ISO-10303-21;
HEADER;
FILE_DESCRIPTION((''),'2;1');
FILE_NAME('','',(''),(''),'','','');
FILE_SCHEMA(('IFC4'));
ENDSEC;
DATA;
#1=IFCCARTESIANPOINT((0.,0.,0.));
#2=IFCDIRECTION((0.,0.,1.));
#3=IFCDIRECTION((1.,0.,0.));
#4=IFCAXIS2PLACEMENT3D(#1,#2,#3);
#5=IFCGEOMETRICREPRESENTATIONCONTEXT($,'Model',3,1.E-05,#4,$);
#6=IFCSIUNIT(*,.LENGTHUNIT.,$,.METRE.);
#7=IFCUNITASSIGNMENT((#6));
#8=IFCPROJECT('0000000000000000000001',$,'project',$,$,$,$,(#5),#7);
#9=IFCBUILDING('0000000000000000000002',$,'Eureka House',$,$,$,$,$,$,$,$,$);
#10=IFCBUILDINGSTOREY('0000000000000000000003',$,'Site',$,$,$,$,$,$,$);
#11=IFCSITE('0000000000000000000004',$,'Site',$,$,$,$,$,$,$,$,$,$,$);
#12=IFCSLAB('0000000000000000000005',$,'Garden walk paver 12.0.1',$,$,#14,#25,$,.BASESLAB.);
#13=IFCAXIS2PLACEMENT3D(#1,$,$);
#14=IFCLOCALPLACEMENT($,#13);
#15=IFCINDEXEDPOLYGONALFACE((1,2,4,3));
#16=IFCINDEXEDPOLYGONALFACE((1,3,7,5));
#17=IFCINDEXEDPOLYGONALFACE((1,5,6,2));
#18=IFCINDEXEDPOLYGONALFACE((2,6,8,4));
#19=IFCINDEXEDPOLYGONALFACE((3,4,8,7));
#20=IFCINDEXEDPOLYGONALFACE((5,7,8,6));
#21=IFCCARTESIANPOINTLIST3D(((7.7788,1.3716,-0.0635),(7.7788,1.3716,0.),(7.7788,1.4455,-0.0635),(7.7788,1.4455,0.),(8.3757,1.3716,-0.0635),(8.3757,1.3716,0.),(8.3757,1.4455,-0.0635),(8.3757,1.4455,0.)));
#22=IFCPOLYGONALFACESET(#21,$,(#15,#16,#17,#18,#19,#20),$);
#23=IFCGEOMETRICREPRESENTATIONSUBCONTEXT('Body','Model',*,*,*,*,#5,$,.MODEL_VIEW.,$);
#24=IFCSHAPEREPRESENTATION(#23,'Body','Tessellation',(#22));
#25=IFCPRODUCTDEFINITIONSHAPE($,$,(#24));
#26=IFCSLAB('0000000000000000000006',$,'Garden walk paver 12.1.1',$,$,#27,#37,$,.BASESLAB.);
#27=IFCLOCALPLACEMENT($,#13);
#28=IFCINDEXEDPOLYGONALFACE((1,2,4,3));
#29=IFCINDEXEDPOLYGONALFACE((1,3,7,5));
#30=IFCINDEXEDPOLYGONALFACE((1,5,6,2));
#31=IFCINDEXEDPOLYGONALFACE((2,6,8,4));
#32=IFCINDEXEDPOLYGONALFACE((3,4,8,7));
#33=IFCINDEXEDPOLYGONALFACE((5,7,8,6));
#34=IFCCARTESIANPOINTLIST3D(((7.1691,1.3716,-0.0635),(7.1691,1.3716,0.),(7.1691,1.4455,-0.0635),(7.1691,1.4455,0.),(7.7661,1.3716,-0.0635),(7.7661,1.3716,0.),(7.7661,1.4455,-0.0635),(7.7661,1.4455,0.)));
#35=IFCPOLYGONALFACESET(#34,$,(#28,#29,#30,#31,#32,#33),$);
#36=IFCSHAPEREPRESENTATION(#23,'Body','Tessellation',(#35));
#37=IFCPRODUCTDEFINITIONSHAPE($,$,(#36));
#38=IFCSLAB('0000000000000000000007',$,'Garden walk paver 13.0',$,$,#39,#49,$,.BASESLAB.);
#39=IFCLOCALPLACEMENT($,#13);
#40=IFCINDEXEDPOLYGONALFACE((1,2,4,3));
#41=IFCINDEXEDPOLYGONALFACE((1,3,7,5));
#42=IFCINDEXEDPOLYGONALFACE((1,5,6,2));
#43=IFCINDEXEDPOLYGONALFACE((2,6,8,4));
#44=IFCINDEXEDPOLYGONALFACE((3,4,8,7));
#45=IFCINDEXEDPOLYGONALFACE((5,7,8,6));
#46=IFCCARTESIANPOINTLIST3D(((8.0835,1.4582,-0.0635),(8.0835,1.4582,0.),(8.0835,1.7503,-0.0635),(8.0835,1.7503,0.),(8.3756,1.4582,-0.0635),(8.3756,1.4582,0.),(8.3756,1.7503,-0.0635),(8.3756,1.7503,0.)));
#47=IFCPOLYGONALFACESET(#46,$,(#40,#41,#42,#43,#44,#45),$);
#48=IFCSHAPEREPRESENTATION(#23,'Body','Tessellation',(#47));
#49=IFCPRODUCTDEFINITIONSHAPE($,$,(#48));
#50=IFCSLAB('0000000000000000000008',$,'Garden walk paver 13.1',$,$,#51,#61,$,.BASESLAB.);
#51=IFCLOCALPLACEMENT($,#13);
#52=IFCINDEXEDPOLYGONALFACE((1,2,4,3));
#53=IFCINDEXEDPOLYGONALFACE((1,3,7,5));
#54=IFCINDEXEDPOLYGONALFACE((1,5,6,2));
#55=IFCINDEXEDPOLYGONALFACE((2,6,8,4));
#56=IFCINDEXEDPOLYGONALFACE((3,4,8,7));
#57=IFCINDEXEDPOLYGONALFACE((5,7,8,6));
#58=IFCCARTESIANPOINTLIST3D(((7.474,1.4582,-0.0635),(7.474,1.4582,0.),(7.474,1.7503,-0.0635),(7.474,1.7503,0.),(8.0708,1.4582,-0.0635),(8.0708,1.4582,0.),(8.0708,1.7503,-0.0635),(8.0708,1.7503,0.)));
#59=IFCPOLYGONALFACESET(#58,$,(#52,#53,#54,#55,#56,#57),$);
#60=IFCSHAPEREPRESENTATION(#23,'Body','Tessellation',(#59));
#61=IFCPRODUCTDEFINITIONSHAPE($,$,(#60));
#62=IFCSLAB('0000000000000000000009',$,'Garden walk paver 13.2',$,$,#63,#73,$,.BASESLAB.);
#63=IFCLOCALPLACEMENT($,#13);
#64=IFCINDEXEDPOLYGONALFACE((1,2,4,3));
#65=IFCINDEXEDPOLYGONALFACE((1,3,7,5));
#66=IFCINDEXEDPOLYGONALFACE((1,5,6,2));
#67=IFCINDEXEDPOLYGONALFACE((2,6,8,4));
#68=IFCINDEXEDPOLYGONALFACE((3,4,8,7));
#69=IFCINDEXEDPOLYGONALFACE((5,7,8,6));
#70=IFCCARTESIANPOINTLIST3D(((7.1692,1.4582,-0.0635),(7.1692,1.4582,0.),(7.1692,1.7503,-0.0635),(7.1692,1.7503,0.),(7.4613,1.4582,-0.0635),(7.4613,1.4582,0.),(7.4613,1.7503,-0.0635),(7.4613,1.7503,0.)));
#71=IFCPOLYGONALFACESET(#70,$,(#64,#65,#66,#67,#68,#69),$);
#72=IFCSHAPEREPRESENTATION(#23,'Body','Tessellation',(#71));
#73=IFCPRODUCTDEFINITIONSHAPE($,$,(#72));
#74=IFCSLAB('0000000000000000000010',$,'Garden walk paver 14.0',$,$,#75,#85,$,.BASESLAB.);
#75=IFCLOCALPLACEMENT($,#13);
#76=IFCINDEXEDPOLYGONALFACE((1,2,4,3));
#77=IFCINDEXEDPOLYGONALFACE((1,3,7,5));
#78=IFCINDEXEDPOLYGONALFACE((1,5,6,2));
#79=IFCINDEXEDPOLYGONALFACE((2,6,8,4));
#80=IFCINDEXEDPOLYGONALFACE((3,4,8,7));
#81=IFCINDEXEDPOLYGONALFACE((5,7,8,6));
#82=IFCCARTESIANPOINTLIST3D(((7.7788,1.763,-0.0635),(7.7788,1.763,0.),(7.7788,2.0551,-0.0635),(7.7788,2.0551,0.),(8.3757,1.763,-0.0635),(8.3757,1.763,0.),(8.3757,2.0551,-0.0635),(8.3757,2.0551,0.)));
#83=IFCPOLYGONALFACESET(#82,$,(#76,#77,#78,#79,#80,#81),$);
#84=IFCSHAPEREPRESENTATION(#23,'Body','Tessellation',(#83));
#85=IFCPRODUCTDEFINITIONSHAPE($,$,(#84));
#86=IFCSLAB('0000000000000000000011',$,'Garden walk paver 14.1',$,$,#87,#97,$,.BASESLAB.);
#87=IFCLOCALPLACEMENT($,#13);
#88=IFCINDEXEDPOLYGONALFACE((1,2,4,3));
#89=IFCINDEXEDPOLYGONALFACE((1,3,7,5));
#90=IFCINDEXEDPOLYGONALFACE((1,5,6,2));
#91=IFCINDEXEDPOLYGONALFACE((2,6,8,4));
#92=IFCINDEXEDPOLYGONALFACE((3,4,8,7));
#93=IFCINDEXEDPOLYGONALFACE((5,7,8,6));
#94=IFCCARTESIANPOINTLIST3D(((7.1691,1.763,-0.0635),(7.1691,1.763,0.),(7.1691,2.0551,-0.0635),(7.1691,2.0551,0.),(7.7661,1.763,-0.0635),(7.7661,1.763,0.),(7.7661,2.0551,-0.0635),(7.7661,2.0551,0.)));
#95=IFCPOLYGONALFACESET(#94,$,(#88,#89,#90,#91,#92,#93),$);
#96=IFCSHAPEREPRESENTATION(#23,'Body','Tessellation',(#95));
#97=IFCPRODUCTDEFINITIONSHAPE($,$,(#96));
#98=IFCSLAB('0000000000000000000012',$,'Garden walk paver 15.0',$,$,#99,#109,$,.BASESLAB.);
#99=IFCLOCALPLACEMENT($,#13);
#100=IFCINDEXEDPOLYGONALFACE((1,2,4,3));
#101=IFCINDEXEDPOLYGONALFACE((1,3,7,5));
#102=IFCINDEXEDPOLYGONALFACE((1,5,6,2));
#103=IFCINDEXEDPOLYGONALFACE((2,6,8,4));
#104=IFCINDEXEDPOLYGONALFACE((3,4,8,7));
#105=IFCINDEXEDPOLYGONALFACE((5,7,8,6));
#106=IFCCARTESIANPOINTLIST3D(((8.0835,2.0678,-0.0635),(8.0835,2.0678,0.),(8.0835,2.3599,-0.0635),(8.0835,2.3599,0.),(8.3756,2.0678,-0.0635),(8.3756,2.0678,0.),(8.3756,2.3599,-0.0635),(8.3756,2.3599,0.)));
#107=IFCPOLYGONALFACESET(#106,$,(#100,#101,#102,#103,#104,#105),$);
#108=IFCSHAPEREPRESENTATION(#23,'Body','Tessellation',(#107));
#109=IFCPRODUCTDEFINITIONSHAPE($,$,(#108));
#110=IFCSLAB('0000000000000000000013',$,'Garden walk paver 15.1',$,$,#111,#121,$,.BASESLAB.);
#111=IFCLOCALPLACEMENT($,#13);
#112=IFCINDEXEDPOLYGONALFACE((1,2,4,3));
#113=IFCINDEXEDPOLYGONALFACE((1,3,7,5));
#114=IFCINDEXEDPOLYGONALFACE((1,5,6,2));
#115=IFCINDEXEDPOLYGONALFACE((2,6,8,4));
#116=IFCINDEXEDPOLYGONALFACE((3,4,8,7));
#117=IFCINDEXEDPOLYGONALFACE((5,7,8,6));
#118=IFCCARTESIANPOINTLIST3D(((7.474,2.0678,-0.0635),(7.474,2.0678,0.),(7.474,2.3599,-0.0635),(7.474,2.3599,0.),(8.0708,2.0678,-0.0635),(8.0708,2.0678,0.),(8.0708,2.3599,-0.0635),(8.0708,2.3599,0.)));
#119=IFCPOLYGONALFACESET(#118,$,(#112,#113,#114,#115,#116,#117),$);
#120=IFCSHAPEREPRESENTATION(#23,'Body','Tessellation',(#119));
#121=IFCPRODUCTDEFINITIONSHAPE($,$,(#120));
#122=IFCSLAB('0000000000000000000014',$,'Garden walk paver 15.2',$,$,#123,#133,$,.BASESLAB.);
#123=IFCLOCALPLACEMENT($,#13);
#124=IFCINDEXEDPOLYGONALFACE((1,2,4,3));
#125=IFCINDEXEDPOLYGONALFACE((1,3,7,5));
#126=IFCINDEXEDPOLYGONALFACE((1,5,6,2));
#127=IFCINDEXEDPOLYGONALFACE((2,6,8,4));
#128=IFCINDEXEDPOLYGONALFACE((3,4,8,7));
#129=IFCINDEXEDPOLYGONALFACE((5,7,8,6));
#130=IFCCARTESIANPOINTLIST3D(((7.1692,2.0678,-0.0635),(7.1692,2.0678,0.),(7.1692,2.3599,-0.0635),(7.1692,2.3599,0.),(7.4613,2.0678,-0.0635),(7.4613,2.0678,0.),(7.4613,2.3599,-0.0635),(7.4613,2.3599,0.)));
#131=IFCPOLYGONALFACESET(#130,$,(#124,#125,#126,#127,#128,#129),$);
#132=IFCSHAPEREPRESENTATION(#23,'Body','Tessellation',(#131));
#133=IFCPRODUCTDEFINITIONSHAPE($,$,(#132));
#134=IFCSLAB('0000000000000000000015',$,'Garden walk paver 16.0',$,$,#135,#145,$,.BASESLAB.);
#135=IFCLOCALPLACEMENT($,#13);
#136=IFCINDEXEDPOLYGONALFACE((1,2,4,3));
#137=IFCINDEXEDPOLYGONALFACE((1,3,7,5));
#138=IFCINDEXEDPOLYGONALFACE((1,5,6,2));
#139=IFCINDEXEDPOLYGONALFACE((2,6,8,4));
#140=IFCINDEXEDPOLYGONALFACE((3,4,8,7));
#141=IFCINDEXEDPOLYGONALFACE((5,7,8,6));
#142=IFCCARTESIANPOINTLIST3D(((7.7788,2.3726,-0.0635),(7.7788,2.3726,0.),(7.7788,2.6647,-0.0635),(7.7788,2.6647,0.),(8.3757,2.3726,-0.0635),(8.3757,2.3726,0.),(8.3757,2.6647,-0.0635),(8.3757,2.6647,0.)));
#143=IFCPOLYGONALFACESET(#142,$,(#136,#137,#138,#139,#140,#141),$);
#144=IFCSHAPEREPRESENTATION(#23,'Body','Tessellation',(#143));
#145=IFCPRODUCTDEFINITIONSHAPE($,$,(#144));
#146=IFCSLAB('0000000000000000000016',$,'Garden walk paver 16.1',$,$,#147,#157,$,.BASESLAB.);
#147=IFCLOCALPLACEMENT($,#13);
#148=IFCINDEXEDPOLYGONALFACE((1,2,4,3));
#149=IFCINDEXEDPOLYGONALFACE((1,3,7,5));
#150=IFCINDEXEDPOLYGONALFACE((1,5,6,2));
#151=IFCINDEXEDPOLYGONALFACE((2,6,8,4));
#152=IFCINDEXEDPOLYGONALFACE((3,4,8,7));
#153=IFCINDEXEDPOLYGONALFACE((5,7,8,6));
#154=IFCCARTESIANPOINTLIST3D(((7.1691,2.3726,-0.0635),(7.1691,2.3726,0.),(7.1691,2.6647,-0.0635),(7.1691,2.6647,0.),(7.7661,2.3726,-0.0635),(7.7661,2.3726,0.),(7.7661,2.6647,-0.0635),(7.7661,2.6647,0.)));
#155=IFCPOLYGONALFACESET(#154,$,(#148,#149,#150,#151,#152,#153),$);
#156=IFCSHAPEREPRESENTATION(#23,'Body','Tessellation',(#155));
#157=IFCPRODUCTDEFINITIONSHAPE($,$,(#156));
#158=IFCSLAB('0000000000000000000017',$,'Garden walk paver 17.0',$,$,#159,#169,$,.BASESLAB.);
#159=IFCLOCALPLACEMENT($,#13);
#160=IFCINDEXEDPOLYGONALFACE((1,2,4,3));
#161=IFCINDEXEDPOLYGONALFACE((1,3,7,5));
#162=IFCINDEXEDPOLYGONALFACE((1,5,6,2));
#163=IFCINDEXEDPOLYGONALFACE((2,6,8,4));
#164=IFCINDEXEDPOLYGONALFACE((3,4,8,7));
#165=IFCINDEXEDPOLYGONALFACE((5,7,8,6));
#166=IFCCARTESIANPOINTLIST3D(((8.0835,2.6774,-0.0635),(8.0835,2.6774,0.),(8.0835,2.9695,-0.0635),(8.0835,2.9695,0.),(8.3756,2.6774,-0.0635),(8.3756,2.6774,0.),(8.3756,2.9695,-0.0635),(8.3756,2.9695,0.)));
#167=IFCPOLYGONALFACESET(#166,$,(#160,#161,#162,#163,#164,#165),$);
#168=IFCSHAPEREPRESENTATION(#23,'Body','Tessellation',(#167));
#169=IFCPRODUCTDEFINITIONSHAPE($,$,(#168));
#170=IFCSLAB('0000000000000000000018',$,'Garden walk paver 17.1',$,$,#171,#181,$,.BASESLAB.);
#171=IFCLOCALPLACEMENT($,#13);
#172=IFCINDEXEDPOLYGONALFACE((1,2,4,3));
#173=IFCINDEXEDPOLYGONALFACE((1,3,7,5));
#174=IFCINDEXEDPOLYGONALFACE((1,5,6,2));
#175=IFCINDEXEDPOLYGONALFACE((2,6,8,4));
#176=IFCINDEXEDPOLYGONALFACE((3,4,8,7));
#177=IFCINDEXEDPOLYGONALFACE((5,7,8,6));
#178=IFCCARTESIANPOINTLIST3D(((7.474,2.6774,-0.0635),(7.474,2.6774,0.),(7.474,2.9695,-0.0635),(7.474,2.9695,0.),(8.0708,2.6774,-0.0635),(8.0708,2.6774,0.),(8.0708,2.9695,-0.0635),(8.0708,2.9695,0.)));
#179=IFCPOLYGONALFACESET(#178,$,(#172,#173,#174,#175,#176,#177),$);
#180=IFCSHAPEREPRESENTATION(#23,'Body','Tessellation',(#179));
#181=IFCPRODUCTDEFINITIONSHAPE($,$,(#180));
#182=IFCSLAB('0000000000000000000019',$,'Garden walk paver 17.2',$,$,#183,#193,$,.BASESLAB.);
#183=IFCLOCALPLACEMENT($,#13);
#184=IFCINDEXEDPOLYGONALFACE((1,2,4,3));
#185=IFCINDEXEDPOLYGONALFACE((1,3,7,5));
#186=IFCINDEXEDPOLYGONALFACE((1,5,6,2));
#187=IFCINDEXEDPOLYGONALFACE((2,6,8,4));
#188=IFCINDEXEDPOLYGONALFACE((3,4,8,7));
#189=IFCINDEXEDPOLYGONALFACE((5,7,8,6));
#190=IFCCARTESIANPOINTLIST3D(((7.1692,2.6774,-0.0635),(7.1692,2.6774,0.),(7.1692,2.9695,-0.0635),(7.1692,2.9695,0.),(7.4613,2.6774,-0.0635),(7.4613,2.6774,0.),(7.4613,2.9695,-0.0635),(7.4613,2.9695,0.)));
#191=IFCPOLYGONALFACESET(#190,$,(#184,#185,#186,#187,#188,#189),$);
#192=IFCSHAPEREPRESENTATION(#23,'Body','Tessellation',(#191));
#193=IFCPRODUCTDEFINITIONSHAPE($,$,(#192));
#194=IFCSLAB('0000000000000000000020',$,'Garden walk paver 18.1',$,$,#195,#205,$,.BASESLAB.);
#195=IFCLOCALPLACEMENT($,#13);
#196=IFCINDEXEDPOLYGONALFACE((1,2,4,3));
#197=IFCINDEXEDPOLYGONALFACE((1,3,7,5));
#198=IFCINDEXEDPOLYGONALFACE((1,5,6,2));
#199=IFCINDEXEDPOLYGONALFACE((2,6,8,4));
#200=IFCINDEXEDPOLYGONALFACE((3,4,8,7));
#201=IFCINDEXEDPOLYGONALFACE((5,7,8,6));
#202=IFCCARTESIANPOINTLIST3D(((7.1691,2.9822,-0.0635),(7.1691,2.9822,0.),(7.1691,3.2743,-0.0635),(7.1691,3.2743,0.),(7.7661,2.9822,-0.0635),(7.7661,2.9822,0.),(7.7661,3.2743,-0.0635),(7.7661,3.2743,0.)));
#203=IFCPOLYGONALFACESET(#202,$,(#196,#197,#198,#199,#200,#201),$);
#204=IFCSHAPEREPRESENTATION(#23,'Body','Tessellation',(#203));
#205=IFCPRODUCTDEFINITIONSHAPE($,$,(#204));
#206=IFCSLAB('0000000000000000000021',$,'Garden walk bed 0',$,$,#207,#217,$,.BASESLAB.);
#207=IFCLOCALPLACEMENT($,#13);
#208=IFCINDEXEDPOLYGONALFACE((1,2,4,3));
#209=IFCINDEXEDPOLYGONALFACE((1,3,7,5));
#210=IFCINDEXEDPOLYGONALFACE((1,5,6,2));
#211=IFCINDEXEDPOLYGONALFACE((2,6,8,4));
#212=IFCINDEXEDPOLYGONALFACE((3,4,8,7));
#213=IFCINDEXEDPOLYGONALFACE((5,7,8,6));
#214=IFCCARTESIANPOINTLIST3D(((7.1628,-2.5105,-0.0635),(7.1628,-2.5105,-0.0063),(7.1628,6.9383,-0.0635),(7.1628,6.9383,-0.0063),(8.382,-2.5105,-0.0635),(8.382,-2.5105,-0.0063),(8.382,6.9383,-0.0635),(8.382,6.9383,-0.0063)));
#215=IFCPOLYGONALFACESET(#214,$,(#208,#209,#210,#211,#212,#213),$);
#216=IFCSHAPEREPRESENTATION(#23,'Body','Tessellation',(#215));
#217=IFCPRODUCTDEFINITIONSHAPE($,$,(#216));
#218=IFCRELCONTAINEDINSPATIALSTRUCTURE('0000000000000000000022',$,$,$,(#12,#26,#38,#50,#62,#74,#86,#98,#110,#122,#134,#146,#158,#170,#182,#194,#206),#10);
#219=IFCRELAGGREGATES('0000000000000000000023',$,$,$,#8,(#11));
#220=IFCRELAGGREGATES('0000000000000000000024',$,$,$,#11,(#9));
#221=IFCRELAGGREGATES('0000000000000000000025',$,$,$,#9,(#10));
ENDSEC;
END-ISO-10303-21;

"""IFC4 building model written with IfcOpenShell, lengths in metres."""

from ifc_helpers import new_model, si_unit, frame, origin, origin_with_axes, origin_2d, place, context, subcontext, project, spatial, rectangle, extrude, element, save


model = new_model("IFC4")

# Units and contexts
model_context = context("Model", 3, precision=1e-05, world=origin_with_axes())
body_context = subcontext(model_context, "Body", "Model", "MODEL_VIEW")
ifc_project = project(units=[si_unit("LENGTHUNIT", "METRE")], contexts=[model_context])

# Site, building, storey
site = spatial("IfcSite", under=ifc_project, Name="Site")
building = spatial("IfcBuilding", under=site, Name="Eureka House")
storey = spatial("IfcBuildingStorey", under=building, Name="Site")

# Slabs
for number, where, z_axis, x_axis, name in (
    (1, (8.0772, 1.4085, -0.0635), (0.0, 0.0, 1.0), (1.0, 0.0, 0.0), "Garden walk paver 12.0.1"),
    (2, (7.4676, 1.4085, -0.0635), (0.0, 0.0, 1.0), (1.0, 0.0, 0.0), "Garden walk paver 12.1.1"),
):
    element("IfcSlab", number, at=place(None, frame(where, z_axis=z_axis, x_axis=x_axis)), inside=storey, Name=name, PredefinedType="BASESLAB", context=body_context, shape_type="SweptSolid", body=[
        extrude(rectangle(XDim=0.5969, YDim=0.0739, at=origin_2d()), origin(), (0.0, 0.0, 1.0), 0.0635),
    ])
slab_1_placement = place(None, frame((8.2296, 1.6043, -0.0635), z_axis=(0.0, 0.0, 1.0), x_axis=(1.0, 0.0, 0.0)))
element("IfcSlab", 3, at=slab_1_placement, inside=storey, Name="Garden walk paver 13.0", PredefinedType="BASESLAB", context=body_context, shape_type="SweptSolid", body=[
    extrude(rectangle(XDim=0.2921, YDim=0.2921, at=origin_2d()), origin(), (0.0, 0.0, 1.0), 0.0635),
])
slab_2_placement = place(None, frame((7.7724, 1.6043, -0.0635), z_axis=(0.0, 0.0, 1.0), x_axis=(1.0, 0.0, 0.0)))
element("IfcSlab", 4, at=slab_2_placement, inside=storey, Name="Garden walk paver 13.1", PredefinedType="BASESLAB", context=body_context, shape_type="SweptSolid", body=[
    extrude(rectangle(XDim=0.5969, YDim=0.2921, at=origin_2d()), origin(), (0.0, 0.0, 1.0), 0.0635),
])
slab_3_placement = place(None, frame((7.3152, 1.6043, -0.0635), z_axis=(0.0, 0.0, 1.0), x_axis=(1.0, 0.0, 0.0)))
element("IfcSlab", 5, at=slab_3_placement, inside=storey, Name="Garden walk paver 13.2", PredefinedType="BASESLAB", context=body_context, shape_type="SweptSolid", body=[
    extrude(rectangle(XDim=0.2921, YDim=0.2921, at=origin_2d()), origin(), (0.0, 0.0, 1.0), 0.0635),
])
for number, where, z_axis, x_axis, name in (
    (6, (8.0772, 1.9091, -0.0635), (0.0, 0.0, 1.0), (1.0, 0.0, 0.0), "Garden walk paver 14.0"),
    (7, (7.4676, 1.9091, -0.0635), (0.0, 0.0, 1.0), (1.0, 0.0, 0.0), "Garden walk paver 14.1"),
):
    element("IfcSlab", number, at=place(None, frame(where, z_axis=z_axis, x_axis=x_axis)), inside=storey, Name=name, PredefinedType="BASESLAB", context=body_context, shape_type="SweptSolid", body=[
        extrude(rectangle(XDim=0.5969, YDim=0.2921, at=origin_2d()), origin(), (0.0, 0.0, 1.0), 0.0635),
    ])
slab_4_placement = place(None, frame((8.2296, 2.2139, -0.0635), z_axis=(0.0, 0.0, 1.0), x_axis=(1.0, 0.0, 0.0)))
element("IfcSlab", 8, at=slab_4_placement, inside=storey, Name="Garden walk paver 15.0", PredefinedType="BASESLAB", context=body_context, shape_type="SweptSolid", body=[
    extrude(rectangle(XDim=0.2921, YDim=0.2921, at=origin_2d()), origin(), (0.0, 0.0, 1.0), 0.0635),
])
slab_5_placement = place(None, frame((7.7724, 2.2139, -0.0635), z_axis=(0.0, 0.0, 1.0), x_axis=(1.0, 0.0, 0.0)))
element("IfcSlab", 9, at=slab_5_placement, inside=storey, Name="Garden walk paver 15.1", PredefinedType="BASESLAB", context=body_context, shape_type="SweptSolid", body=[
    extrude(rectangle(XDim=0.5969, YDim=0.2921, at=origin_2d()), origin(), (0.0, 0.0, 1.0), 0.0635),
])
slab_6_placement = place(None, frame((7.3152, 2.2139, -0.0635), z_axis=(0.0, 0.0, 1.0), x_axis=(1.0, 0.0, 0.0)))
element("IfcSlab", 10, at=slab_6_placement, inside=storey, Name="Garden walk paver 15.2", PredefinedType="BASESLAB", context=body_context, shape_type="SweptSolid", body=[
    extrude(rectangle(XDim=0.2921, YDim=0.2921, at=origin_2d()), origin(), (0.0, 0.0, 1.0), 0.0635),
])
for number, where, z_axis, x_axis, name in (
    (11, (8.0772, 2.5187, -0.0635), (0.0, 0.0, 1.0), (1.0, 0.0, 0.0), "Garden walk paver 16.0"),
    (12, (7.4676, 2.5187, -0.0635), (0.0, 0.0, 1.0), (1.0, 0.0, 0.0), "Garden walk paver 16.1"),
):
    element("IfcSlab", number, at=place(None, frame(where, z_axis=z_axis, x_axis=x_axis)), inside=storey, Name=name, PredefinedType="BASESLAB", context=body_context, shape_type="SweptSolid", body=[
        extrude(rectangle(XDim=0.5969, YDim=0.2921, at=origin_2d()), origin(), (0.0, 0.0, 1.0), 0.0635),
    ])
slab_7_placement = place(None, frame((8.2296, 2.8235, -0.0635), z_axis=(0.0, 0.0, 1.0), x_axis=(1.0, 0.0, 0.0)))
element("IfcSlab", 13, at=slab_7_placement, inside=storey, Name="Garden walk paver 17.0", PredefinedType="BASESLAB", context=body_context, shape_type="SweptSolid", body=[
    extrude(rectangle(XDim=0.2921, YDim=0.2921, at=origin_2d()), origin(), (0.0, 0.0, 1.0), 0.0635),
])
slab_8_placement = place(None, frame((7.7724, 2.8235, -0.0635), z_axis=(0.0, 0.0, 1.0), x_axis=(1.0, 0.0, 0.0)))
element("IfcSlab", 14, at=slab_8_placement, inside=storey, Name="Garden walk paver 17.1", PredefinedType="BASESLAB", context=body_context, shape_type="SweptSolid", body=[
    extrude(rectangle(XDim=0.5969, YDim=0.2921, at=origin_2d()), origin(), (0.0, 0.0, 1.0), 0.0635),
])
slab_9_placement = place(None, frame((7.3152, 2.8235, -0.0635), z_axis=(0.0, 0.0, 1.0), x_axis=(1.0, 0.0, 0.0)))
element("IfcSlab", 15, at=slab_9_placement, inside=storey, Name="Garden walk paver 17.2", PredefinedType="BASESLAB", context=body_context, shape_type="SweptSolid", body=[
    extrude(rectangle(XDim=0.2921, YDim=0.2921, at=origin_2d()), origin(), (0.0, 0.0, 1.0), 0.0635),
])
slab_10_placement = place(None, frame((7.4676, 3.1283, -0.0635), z_axis=(0.0, 0.0, 1.0), x_axis=(1.0, 0.0, 0.0)))
element("IfcSlab", 16, at=slab_10_placement, inside=storey, Name="Garden walk paver 18.1", PredefinedType="BASESLAB", context=body_context, shape_type="SweptSolid", body=[
    extrude(rectangle(XDim=0.5969, YDim=0.2921, at=origin_2d()), origin(), (0.0, 0.0, 1.0), 0.0635),
])
slab_11_placement = place(None, frame((7.7724, 2.2139, -0.0635), z_axis=(0.0, 0.0, 1.0), x_axis=(1.0, 0.0, 0.0)))
element("IfcSlab", 17, at=slab_11_placement, inside=storey, Name="Garden walk bed 0", PredefinedType="BASESLAB", context=body_context, shape_type="SweptSolid", body=[
    extrude(rectangle(XDim=1.2192, YDim=9.4488, at=origin_2d()), origin(), (0.0, 0.0, 1.0), 0.0572),
])

save(model, "model.ifc")
